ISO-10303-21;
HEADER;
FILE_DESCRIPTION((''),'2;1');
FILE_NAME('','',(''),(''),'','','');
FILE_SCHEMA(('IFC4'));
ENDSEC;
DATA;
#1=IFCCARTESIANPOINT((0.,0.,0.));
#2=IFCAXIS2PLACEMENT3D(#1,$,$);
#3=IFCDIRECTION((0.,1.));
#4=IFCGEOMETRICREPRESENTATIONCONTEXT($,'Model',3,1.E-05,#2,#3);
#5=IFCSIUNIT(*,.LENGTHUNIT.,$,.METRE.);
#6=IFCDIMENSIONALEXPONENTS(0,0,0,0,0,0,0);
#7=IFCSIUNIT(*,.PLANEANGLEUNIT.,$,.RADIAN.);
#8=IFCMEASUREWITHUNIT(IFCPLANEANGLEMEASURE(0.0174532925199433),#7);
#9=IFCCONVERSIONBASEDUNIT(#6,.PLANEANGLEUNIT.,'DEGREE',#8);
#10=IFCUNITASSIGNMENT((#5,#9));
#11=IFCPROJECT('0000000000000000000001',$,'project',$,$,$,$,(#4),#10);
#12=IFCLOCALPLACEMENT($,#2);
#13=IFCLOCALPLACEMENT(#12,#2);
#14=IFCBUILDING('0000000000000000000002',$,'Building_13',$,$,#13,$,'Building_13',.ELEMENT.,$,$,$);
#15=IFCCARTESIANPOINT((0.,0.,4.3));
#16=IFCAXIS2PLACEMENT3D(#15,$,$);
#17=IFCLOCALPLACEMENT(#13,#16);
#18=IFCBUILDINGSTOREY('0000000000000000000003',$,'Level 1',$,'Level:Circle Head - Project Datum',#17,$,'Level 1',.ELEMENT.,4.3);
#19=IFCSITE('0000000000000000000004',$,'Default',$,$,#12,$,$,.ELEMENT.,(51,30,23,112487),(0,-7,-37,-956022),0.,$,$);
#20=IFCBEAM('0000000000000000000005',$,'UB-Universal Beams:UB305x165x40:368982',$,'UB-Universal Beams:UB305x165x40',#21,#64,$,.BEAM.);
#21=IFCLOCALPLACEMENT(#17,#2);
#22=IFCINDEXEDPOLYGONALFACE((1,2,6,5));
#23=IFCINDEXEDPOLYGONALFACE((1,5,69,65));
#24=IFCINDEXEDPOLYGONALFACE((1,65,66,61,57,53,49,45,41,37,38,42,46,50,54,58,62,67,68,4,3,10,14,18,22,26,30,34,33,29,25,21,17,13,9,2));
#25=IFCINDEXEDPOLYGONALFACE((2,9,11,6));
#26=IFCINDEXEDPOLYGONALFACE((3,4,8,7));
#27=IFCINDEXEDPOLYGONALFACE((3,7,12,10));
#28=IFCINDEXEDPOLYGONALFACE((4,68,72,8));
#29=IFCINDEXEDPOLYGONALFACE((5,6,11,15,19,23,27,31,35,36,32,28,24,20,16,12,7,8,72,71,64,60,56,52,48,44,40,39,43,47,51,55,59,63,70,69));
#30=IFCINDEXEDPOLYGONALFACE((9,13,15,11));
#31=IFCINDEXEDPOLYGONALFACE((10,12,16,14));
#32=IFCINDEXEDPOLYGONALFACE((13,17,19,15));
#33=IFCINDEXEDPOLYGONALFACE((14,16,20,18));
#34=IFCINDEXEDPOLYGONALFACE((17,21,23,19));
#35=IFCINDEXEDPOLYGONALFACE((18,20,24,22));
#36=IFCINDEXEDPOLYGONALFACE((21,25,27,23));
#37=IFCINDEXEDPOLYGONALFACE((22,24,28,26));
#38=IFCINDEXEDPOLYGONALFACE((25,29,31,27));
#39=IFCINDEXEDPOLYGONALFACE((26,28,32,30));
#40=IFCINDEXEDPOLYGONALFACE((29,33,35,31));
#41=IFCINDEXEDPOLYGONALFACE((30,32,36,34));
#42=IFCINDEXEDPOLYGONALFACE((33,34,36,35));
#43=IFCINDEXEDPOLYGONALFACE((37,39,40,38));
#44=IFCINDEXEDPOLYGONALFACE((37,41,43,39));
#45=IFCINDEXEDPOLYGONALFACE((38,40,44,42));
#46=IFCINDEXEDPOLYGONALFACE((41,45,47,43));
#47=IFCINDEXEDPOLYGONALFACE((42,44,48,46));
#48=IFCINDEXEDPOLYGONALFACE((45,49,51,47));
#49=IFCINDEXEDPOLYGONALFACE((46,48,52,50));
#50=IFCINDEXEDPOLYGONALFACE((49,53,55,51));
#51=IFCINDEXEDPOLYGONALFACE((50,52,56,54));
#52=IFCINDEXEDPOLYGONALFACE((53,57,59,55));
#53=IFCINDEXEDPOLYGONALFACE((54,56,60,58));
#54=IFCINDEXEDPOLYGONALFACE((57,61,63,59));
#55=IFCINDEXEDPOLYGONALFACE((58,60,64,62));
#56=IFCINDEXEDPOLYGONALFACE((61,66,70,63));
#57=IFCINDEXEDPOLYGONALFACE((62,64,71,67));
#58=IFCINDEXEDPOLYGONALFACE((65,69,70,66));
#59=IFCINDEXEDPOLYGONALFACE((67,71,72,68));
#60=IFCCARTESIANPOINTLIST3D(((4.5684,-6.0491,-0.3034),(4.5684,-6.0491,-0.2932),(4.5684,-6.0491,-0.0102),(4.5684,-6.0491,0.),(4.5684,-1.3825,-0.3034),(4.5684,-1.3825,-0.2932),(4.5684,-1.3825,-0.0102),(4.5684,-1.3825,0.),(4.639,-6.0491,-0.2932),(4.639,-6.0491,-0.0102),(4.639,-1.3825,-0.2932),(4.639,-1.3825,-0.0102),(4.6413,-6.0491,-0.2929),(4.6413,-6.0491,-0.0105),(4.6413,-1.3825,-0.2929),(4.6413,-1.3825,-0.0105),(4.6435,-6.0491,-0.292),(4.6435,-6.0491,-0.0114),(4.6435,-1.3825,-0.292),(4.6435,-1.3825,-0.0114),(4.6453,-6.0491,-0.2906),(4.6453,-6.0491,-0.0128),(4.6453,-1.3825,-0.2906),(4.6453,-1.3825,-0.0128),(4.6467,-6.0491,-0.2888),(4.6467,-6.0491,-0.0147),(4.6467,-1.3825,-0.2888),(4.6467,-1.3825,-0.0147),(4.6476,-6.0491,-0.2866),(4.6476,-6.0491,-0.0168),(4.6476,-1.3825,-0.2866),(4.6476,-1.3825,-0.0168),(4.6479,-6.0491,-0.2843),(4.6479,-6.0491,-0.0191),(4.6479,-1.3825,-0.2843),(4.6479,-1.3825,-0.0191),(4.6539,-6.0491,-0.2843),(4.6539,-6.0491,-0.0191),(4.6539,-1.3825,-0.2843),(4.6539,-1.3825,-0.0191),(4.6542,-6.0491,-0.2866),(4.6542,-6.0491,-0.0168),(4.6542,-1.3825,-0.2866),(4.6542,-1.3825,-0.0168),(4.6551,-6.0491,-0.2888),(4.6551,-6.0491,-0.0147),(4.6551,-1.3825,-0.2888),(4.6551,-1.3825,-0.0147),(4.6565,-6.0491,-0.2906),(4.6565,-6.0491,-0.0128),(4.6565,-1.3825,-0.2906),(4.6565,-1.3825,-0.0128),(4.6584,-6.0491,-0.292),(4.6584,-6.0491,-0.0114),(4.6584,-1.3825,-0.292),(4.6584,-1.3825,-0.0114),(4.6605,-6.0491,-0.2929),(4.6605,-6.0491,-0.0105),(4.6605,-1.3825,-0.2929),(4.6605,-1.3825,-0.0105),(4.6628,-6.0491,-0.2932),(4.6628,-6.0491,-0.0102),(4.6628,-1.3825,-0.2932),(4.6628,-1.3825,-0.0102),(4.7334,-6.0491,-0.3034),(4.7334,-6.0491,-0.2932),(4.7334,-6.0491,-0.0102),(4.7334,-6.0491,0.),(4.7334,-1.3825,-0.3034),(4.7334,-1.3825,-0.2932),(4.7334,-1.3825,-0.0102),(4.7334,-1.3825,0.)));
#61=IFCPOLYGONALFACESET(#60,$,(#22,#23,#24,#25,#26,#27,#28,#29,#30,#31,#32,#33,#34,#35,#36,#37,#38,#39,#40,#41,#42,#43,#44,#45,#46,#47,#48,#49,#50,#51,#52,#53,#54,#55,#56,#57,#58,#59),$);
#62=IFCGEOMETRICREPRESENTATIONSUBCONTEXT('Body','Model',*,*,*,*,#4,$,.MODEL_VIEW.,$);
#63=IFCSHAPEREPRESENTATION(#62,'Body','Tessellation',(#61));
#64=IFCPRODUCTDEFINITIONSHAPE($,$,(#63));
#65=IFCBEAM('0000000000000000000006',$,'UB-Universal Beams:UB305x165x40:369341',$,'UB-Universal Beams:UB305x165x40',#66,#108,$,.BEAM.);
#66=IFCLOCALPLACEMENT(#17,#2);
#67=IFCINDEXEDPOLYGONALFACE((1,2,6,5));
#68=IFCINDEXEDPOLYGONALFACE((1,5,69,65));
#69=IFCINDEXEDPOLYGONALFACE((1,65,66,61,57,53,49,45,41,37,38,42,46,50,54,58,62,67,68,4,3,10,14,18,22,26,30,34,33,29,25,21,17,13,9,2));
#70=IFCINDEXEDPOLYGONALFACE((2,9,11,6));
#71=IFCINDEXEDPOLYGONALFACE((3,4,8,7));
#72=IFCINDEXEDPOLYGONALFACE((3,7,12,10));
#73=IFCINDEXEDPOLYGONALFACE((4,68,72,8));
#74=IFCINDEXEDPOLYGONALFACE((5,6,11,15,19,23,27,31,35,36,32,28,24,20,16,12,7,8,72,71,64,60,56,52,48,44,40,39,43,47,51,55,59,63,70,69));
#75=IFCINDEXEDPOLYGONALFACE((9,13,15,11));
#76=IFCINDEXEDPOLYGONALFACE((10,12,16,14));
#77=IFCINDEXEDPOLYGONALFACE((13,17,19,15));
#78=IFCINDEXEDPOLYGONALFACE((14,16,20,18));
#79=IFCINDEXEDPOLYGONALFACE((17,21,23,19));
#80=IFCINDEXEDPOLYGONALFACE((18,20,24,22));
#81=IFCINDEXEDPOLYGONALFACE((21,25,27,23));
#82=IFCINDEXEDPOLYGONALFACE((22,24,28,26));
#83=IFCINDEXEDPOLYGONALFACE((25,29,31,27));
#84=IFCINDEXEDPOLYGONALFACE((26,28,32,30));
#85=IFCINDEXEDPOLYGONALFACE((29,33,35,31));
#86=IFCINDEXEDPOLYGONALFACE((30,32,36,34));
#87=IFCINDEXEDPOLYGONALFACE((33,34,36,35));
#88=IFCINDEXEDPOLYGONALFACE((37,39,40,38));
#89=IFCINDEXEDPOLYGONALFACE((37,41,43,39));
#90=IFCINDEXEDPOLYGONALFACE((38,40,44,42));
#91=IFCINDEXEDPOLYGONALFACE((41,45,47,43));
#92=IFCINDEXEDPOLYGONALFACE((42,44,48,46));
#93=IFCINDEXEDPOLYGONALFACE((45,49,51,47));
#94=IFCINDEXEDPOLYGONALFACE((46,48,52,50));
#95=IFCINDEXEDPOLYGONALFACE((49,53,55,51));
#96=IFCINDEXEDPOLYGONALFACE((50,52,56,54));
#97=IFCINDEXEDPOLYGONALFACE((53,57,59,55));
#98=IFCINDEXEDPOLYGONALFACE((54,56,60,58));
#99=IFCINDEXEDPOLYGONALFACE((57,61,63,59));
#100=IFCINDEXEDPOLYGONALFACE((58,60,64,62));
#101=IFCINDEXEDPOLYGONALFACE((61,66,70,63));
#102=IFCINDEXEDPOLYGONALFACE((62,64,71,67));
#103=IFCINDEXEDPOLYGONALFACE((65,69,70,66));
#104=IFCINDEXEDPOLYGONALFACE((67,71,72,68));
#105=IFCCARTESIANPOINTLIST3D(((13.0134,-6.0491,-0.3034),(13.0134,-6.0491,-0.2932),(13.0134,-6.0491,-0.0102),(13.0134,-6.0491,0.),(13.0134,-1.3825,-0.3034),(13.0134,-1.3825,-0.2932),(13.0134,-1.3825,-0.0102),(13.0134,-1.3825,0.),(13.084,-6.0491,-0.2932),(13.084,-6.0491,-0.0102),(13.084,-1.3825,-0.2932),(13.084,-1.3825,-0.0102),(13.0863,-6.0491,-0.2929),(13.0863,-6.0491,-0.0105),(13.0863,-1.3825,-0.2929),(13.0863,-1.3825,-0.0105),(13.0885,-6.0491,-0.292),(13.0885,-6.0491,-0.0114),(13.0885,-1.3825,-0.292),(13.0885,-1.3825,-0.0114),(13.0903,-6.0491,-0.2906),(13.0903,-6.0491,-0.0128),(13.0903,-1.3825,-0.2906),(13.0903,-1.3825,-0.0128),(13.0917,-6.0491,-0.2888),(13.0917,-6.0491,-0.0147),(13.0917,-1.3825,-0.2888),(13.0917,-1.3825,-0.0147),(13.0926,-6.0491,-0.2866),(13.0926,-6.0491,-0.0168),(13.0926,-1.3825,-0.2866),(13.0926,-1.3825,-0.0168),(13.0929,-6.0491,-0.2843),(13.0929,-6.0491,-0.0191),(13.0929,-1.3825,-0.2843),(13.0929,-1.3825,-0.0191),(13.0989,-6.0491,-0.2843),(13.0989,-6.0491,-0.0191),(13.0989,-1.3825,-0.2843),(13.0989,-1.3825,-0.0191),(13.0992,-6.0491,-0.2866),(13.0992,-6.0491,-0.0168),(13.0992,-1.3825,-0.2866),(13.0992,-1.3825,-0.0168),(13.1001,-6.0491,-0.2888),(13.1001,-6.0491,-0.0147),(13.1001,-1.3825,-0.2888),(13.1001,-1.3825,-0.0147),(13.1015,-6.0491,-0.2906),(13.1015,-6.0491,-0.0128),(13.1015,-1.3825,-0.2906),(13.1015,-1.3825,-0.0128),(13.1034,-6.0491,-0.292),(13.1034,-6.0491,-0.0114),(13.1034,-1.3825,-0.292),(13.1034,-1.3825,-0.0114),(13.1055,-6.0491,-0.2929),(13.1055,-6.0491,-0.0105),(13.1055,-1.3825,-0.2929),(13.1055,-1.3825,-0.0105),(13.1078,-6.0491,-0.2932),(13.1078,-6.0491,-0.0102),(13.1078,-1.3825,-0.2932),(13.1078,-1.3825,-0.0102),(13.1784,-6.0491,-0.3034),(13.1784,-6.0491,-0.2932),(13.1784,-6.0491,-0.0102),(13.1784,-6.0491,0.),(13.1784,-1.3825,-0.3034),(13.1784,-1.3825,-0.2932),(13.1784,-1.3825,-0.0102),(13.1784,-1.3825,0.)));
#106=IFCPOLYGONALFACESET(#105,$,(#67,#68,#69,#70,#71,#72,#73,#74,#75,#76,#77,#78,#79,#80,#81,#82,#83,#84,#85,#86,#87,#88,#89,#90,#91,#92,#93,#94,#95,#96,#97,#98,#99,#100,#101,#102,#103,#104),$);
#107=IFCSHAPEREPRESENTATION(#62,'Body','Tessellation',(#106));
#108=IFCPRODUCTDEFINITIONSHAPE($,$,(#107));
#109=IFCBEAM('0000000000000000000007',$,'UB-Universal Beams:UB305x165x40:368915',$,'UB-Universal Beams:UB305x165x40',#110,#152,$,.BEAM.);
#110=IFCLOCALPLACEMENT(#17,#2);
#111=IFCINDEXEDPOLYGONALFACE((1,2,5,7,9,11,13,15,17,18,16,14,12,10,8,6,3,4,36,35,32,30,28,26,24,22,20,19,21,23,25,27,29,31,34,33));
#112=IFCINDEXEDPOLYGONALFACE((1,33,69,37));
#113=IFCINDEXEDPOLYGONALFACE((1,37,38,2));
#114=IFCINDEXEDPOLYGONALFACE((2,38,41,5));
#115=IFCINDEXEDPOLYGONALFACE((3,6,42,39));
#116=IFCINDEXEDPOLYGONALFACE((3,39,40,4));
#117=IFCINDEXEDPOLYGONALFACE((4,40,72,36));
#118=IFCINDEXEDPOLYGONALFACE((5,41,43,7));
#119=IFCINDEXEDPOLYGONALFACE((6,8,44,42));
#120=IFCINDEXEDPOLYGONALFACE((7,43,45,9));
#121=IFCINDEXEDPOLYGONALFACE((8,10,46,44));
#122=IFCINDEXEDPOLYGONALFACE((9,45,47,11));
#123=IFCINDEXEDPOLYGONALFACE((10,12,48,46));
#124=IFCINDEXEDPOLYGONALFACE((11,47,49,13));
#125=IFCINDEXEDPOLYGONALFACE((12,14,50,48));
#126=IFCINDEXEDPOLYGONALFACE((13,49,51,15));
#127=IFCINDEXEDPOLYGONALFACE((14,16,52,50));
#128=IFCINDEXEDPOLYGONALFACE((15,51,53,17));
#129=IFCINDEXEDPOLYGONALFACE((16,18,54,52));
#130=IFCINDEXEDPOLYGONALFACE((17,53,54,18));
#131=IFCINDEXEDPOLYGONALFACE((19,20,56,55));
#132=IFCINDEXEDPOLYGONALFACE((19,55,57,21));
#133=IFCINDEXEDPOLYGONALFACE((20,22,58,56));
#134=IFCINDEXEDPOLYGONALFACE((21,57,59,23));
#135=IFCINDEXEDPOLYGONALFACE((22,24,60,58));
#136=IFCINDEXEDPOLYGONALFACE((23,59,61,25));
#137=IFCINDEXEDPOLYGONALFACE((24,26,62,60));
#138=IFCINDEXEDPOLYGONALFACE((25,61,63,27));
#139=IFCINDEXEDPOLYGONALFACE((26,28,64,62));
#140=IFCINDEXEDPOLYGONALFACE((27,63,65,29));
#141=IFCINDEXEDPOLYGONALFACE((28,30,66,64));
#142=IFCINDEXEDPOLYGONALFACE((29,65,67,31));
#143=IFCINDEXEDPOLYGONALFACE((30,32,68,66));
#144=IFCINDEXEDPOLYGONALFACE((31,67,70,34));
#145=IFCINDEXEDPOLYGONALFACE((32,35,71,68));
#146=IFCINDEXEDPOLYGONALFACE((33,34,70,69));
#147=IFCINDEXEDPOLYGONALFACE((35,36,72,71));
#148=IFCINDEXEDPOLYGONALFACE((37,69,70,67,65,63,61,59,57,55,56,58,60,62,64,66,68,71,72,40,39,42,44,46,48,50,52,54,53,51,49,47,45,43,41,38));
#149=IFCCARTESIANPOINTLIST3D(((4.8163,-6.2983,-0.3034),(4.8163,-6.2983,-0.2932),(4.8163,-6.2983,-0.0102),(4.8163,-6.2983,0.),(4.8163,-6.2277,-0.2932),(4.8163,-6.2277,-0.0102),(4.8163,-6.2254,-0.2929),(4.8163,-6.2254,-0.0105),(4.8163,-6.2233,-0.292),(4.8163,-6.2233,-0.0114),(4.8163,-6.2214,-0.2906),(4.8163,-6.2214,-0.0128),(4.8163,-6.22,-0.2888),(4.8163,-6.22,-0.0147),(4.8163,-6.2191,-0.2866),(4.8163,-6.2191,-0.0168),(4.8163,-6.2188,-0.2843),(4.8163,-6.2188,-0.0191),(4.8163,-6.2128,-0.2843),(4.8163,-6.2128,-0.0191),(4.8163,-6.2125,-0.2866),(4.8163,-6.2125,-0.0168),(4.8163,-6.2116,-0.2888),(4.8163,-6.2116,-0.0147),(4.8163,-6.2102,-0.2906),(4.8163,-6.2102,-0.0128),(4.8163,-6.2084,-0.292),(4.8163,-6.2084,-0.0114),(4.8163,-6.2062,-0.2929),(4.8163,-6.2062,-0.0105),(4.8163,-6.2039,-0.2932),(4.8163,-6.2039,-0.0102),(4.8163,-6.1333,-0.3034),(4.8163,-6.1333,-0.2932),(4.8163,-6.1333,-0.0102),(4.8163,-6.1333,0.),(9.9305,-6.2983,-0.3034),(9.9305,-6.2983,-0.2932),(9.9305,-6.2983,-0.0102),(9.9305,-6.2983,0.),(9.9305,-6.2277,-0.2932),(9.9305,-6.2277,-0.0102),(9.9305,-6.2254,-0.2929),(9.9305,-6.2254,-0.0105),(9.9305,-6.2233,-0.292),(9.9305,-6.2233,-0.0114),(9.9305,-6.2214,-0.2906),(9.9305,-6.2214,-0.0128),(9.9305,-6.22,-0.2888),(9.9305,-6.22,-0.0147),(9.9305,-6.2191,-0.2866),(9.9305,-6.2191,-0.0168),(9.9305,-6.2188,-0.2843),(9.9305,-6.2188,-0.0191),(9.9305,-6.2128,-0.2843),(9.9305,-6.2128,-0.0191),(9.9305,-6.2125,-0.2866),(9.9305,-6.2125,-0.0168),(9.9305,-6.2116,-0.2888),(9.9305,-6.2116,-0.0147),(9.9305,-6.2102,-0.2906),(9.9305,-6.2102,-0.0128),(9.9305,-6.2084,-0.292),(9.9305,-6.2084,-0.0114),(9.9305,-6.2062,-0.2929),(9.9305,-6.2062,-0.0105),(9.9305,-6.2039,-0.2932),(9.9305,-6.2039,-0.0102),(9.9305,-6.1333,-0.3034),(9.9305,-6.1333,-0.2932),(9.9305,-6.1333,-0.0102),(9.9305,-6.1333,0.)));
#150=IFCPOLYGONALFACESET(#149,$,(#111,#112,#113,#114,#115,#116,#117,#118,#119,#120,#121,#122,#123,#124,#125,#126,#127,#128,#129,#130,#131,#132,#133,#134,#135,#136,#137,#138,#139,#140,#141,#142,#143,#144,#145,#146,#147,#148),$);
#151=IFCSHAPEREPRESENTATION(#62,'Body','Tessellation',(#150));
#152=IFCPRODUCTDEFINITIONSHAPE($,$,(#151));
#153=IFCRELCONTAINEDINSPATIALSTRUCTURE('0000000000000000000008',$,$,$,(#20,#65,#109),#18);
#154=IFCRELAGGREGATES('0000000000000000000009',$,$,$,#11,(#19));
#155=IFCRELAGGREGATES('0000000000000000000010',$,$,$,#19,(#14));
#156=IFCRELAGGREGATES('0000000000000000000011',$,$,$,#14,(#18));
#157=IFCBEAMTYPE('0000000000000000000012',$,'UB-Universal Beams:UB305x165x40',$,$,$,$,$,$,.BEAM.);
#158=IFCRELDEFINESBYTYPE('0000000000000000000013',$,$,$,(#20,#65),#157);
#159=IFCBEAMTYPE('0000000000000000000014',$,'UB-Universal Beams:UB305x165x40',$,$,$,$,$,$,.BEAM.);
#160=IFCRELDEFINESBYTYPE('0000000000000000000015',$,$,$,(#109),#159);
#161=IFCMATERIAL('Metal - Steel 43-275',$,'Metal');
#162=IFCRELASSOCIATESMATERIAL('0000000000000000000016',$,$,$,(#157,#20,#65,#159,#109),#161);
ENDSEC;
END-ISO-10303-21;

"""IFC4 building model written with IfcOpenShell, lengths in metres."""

from ifc_helpers import new_model, entity, si_unit, converted_unit, direction, frame, origin, place, context, subcontext, project, spatial, line, arc, indexed_curve, outline, extrude, source, transform, mapped, material, type_object, type_shapes, element, save


model = new_model("IFC4")

# Units and contexts
model_context = context("Model", 3, precision=1e-05, world=origin(), true_north=direction((0.0, 1.0)))
body_context = subcontext(model_context, "Body", "Model", "MODEL_VIEW")
ifc_project = project(units=[si_unit("LENGTHUNIT", "METRE"), converted_unit("PLANEANGLEUNIT", "DEGREE", entity("IfcPlaneAngleMeasure", 0.0174532925199433), si_unit("PLANEANGLEUNIT", "RADIAN"), dimensions=[0, 0, 0, 0, 0, 0, 0])], contexts=[model_context])

# Site, building, storey
site_placement = place(None, origin())
site = spatial("IfcSite", under=ifc_project, at=site_placement, Name="Default", CompositionType="ELEMENT", RefLatitude=(51, 30, 23, 112487), RefLongitude=(0, -7, -37, -956022), RefElevation=0.0)
building_placement = place(site_placement, origin())
building = spatial("IfcBuilding", under=site, at=building_placement, Name="Building_13", LongName="Building_13", CompositionType="ELEMENT")
storey_placement = place(building_placement, frame((0.0, 0.0, 4.3)))
storey = spatial("IfcBuildingStorey", under=building, at=storey_placement, Name="Level 1", ObjectType="Level:Circle Head - Project Datum", LongName="Level 1", CompositionType="ELEMENT", Elevation=4.3)

# Beams
ifc_material_1 = material(Name="Metal - Steel 43-275", Category="Metal")
beam_type_1 = type_object("IfcBeamType", Name="UB-Universal Beams:UB305x165x40", PredefinedType="BEAM", material=ifc_material_1)
shared_shape_1 = source(origin(), body_context, "Body", "SweptSolid", [
    extrude(outline(indexed_curve([(-0.0825, -0.1415), (-0.0825, -0.1517), (0.0825, -0.1517), (0.0825, -0.1415), (0.0119, -0.1415), (0.0056, -0.1389), (0.003, -0.1326), (0.003, 0.1326), (0.0056, 0.1389), (0.0119, 0.1415), (0.0825, 0.1415), (0.0825, 0.1517), (-0.0825, 0.1517), (-0.0825, 0.1415), (-0.0119, 0.1415), (-0.0056, 0.1389), (-0.003, 0.1326), (-0.003, -0.1326), (-0.0056, -0.1389), (-0.0119, -0.1415)], segments=[line(1, 2, 3, 4, 5), arc(5, 6, 7), line(7, 8), arc(8, 9, 10), line(10, 11, 12, 13, 14, 15), arc(15, 16, 17), line(17, 18), arc(18, 19, 20), line(20, 1)], self_intersect=False)), frame((-2.3333, 0.0, 0.0), z_axis=(-1.0, 0.0, 0.0), x_axis=(0.0, -1.0, 0.0)), (0.0, 0.0, -1.0), 4.6666),
])
type_shapes(beam_type_1, [shared_shape_1])
for number, where, z_axis, x_axis, name in (
    (1, (4.6509, -3.7158, -0.1517), (0.0, 0.0, 1.0), (0.0, -1.0, 0.0), "UB-Universal Beams:UB305x165x40:368982"),
    (2, (13.0959, -3.7158, -0.1517), (0.0, 0.0, 1.0), (0.0, -1.0, 0.0), "UB-Universal Beams:UB305x165x40:369341"),
):
    element("IfcBeam", number, at=place(storey_placement, frame(where, z_axis=z_axis, x_axis=x_axis)), inside=storey, type_object=beam_type_1, material=ifc_material_1, Name=name, ObjectType="UB-Universal Beams:UB305x165x40", PredefinedType="BEAM", context=body_context, shape_type="MappedRepresentation", body=[
        mapped(shared_shape_1, transform((0.0, 0.0, 0.0), scale=1.0)),
    ])
beam_type_2 = type_object("IfcBeamType", Name="UB-Universal Beams:UB305x165x40", PredefinedType="BEAM", material=ifc_material_1)
shared_shape_2 = source(origin(), body_context, "Body", "SweptSolid", [
    extrude(outline(indexed_curve([(-0.0825, -0.1415), (-0.0825, -0.1517), (0.0825, -0.1517), (0.0825, -0.1415), (0.0119, -0.1415), (0.0056, -0.1389), (0.003, -0.1326), (0.003, 0.1326), (0.0056, 0.1389), (0.0119, 0.1415), (0.0825, 0.1415), (0.0825, 0.1517), (-0.0825, 0.1517), (-0.0825, 0.1415), (-0.0119, 0.1415), (-0.0056, 0.1389), (-0.003, 0.1326), (-0.003, -0.1326), (-0.0056, -0.1389), (-0.0119, -0.1415)], segments=[line(1, 2, 3, 4, 5), arc(5, 6, 7), line(7, 8), arc(8, 9, 10), line(10, 11, 12, 13, 14, 15), arc(15, 16, 17), line(17, 18), arc(18, 19, 20), line(20, 1)], self_intersect=False)), frame((-2.5571, 0.0, 0.0), z_axis=(-1.0, 0.0, 0.0), x_axis=(0.0, -1.0, 0.0)), (0.0, 0.0, -1.0), 5.1142),
])
type_shapes(beam_type_2, [shared_shape_2])
beam_1_placement = place(storey_placement, frame((7.3734, -6.2158, -0.1517)))
element("IfcBeam", 3, at=beam_1_placement, inside=storey, type_object=beam_type_2, material=ifc_material_1, Name="UB-Universal Beams:UB305x165x40:368915", ObjectType="UB-Universal Beams:UB305x165x40", PredefinedType="BEAM", context=body_context, shape_type="MappedRepresentation", body=[
    mapped(shared_shape_2, transform((0.0, 0.0, 0.0), scale=1.0)),
])

save(model, "model.ifc")
